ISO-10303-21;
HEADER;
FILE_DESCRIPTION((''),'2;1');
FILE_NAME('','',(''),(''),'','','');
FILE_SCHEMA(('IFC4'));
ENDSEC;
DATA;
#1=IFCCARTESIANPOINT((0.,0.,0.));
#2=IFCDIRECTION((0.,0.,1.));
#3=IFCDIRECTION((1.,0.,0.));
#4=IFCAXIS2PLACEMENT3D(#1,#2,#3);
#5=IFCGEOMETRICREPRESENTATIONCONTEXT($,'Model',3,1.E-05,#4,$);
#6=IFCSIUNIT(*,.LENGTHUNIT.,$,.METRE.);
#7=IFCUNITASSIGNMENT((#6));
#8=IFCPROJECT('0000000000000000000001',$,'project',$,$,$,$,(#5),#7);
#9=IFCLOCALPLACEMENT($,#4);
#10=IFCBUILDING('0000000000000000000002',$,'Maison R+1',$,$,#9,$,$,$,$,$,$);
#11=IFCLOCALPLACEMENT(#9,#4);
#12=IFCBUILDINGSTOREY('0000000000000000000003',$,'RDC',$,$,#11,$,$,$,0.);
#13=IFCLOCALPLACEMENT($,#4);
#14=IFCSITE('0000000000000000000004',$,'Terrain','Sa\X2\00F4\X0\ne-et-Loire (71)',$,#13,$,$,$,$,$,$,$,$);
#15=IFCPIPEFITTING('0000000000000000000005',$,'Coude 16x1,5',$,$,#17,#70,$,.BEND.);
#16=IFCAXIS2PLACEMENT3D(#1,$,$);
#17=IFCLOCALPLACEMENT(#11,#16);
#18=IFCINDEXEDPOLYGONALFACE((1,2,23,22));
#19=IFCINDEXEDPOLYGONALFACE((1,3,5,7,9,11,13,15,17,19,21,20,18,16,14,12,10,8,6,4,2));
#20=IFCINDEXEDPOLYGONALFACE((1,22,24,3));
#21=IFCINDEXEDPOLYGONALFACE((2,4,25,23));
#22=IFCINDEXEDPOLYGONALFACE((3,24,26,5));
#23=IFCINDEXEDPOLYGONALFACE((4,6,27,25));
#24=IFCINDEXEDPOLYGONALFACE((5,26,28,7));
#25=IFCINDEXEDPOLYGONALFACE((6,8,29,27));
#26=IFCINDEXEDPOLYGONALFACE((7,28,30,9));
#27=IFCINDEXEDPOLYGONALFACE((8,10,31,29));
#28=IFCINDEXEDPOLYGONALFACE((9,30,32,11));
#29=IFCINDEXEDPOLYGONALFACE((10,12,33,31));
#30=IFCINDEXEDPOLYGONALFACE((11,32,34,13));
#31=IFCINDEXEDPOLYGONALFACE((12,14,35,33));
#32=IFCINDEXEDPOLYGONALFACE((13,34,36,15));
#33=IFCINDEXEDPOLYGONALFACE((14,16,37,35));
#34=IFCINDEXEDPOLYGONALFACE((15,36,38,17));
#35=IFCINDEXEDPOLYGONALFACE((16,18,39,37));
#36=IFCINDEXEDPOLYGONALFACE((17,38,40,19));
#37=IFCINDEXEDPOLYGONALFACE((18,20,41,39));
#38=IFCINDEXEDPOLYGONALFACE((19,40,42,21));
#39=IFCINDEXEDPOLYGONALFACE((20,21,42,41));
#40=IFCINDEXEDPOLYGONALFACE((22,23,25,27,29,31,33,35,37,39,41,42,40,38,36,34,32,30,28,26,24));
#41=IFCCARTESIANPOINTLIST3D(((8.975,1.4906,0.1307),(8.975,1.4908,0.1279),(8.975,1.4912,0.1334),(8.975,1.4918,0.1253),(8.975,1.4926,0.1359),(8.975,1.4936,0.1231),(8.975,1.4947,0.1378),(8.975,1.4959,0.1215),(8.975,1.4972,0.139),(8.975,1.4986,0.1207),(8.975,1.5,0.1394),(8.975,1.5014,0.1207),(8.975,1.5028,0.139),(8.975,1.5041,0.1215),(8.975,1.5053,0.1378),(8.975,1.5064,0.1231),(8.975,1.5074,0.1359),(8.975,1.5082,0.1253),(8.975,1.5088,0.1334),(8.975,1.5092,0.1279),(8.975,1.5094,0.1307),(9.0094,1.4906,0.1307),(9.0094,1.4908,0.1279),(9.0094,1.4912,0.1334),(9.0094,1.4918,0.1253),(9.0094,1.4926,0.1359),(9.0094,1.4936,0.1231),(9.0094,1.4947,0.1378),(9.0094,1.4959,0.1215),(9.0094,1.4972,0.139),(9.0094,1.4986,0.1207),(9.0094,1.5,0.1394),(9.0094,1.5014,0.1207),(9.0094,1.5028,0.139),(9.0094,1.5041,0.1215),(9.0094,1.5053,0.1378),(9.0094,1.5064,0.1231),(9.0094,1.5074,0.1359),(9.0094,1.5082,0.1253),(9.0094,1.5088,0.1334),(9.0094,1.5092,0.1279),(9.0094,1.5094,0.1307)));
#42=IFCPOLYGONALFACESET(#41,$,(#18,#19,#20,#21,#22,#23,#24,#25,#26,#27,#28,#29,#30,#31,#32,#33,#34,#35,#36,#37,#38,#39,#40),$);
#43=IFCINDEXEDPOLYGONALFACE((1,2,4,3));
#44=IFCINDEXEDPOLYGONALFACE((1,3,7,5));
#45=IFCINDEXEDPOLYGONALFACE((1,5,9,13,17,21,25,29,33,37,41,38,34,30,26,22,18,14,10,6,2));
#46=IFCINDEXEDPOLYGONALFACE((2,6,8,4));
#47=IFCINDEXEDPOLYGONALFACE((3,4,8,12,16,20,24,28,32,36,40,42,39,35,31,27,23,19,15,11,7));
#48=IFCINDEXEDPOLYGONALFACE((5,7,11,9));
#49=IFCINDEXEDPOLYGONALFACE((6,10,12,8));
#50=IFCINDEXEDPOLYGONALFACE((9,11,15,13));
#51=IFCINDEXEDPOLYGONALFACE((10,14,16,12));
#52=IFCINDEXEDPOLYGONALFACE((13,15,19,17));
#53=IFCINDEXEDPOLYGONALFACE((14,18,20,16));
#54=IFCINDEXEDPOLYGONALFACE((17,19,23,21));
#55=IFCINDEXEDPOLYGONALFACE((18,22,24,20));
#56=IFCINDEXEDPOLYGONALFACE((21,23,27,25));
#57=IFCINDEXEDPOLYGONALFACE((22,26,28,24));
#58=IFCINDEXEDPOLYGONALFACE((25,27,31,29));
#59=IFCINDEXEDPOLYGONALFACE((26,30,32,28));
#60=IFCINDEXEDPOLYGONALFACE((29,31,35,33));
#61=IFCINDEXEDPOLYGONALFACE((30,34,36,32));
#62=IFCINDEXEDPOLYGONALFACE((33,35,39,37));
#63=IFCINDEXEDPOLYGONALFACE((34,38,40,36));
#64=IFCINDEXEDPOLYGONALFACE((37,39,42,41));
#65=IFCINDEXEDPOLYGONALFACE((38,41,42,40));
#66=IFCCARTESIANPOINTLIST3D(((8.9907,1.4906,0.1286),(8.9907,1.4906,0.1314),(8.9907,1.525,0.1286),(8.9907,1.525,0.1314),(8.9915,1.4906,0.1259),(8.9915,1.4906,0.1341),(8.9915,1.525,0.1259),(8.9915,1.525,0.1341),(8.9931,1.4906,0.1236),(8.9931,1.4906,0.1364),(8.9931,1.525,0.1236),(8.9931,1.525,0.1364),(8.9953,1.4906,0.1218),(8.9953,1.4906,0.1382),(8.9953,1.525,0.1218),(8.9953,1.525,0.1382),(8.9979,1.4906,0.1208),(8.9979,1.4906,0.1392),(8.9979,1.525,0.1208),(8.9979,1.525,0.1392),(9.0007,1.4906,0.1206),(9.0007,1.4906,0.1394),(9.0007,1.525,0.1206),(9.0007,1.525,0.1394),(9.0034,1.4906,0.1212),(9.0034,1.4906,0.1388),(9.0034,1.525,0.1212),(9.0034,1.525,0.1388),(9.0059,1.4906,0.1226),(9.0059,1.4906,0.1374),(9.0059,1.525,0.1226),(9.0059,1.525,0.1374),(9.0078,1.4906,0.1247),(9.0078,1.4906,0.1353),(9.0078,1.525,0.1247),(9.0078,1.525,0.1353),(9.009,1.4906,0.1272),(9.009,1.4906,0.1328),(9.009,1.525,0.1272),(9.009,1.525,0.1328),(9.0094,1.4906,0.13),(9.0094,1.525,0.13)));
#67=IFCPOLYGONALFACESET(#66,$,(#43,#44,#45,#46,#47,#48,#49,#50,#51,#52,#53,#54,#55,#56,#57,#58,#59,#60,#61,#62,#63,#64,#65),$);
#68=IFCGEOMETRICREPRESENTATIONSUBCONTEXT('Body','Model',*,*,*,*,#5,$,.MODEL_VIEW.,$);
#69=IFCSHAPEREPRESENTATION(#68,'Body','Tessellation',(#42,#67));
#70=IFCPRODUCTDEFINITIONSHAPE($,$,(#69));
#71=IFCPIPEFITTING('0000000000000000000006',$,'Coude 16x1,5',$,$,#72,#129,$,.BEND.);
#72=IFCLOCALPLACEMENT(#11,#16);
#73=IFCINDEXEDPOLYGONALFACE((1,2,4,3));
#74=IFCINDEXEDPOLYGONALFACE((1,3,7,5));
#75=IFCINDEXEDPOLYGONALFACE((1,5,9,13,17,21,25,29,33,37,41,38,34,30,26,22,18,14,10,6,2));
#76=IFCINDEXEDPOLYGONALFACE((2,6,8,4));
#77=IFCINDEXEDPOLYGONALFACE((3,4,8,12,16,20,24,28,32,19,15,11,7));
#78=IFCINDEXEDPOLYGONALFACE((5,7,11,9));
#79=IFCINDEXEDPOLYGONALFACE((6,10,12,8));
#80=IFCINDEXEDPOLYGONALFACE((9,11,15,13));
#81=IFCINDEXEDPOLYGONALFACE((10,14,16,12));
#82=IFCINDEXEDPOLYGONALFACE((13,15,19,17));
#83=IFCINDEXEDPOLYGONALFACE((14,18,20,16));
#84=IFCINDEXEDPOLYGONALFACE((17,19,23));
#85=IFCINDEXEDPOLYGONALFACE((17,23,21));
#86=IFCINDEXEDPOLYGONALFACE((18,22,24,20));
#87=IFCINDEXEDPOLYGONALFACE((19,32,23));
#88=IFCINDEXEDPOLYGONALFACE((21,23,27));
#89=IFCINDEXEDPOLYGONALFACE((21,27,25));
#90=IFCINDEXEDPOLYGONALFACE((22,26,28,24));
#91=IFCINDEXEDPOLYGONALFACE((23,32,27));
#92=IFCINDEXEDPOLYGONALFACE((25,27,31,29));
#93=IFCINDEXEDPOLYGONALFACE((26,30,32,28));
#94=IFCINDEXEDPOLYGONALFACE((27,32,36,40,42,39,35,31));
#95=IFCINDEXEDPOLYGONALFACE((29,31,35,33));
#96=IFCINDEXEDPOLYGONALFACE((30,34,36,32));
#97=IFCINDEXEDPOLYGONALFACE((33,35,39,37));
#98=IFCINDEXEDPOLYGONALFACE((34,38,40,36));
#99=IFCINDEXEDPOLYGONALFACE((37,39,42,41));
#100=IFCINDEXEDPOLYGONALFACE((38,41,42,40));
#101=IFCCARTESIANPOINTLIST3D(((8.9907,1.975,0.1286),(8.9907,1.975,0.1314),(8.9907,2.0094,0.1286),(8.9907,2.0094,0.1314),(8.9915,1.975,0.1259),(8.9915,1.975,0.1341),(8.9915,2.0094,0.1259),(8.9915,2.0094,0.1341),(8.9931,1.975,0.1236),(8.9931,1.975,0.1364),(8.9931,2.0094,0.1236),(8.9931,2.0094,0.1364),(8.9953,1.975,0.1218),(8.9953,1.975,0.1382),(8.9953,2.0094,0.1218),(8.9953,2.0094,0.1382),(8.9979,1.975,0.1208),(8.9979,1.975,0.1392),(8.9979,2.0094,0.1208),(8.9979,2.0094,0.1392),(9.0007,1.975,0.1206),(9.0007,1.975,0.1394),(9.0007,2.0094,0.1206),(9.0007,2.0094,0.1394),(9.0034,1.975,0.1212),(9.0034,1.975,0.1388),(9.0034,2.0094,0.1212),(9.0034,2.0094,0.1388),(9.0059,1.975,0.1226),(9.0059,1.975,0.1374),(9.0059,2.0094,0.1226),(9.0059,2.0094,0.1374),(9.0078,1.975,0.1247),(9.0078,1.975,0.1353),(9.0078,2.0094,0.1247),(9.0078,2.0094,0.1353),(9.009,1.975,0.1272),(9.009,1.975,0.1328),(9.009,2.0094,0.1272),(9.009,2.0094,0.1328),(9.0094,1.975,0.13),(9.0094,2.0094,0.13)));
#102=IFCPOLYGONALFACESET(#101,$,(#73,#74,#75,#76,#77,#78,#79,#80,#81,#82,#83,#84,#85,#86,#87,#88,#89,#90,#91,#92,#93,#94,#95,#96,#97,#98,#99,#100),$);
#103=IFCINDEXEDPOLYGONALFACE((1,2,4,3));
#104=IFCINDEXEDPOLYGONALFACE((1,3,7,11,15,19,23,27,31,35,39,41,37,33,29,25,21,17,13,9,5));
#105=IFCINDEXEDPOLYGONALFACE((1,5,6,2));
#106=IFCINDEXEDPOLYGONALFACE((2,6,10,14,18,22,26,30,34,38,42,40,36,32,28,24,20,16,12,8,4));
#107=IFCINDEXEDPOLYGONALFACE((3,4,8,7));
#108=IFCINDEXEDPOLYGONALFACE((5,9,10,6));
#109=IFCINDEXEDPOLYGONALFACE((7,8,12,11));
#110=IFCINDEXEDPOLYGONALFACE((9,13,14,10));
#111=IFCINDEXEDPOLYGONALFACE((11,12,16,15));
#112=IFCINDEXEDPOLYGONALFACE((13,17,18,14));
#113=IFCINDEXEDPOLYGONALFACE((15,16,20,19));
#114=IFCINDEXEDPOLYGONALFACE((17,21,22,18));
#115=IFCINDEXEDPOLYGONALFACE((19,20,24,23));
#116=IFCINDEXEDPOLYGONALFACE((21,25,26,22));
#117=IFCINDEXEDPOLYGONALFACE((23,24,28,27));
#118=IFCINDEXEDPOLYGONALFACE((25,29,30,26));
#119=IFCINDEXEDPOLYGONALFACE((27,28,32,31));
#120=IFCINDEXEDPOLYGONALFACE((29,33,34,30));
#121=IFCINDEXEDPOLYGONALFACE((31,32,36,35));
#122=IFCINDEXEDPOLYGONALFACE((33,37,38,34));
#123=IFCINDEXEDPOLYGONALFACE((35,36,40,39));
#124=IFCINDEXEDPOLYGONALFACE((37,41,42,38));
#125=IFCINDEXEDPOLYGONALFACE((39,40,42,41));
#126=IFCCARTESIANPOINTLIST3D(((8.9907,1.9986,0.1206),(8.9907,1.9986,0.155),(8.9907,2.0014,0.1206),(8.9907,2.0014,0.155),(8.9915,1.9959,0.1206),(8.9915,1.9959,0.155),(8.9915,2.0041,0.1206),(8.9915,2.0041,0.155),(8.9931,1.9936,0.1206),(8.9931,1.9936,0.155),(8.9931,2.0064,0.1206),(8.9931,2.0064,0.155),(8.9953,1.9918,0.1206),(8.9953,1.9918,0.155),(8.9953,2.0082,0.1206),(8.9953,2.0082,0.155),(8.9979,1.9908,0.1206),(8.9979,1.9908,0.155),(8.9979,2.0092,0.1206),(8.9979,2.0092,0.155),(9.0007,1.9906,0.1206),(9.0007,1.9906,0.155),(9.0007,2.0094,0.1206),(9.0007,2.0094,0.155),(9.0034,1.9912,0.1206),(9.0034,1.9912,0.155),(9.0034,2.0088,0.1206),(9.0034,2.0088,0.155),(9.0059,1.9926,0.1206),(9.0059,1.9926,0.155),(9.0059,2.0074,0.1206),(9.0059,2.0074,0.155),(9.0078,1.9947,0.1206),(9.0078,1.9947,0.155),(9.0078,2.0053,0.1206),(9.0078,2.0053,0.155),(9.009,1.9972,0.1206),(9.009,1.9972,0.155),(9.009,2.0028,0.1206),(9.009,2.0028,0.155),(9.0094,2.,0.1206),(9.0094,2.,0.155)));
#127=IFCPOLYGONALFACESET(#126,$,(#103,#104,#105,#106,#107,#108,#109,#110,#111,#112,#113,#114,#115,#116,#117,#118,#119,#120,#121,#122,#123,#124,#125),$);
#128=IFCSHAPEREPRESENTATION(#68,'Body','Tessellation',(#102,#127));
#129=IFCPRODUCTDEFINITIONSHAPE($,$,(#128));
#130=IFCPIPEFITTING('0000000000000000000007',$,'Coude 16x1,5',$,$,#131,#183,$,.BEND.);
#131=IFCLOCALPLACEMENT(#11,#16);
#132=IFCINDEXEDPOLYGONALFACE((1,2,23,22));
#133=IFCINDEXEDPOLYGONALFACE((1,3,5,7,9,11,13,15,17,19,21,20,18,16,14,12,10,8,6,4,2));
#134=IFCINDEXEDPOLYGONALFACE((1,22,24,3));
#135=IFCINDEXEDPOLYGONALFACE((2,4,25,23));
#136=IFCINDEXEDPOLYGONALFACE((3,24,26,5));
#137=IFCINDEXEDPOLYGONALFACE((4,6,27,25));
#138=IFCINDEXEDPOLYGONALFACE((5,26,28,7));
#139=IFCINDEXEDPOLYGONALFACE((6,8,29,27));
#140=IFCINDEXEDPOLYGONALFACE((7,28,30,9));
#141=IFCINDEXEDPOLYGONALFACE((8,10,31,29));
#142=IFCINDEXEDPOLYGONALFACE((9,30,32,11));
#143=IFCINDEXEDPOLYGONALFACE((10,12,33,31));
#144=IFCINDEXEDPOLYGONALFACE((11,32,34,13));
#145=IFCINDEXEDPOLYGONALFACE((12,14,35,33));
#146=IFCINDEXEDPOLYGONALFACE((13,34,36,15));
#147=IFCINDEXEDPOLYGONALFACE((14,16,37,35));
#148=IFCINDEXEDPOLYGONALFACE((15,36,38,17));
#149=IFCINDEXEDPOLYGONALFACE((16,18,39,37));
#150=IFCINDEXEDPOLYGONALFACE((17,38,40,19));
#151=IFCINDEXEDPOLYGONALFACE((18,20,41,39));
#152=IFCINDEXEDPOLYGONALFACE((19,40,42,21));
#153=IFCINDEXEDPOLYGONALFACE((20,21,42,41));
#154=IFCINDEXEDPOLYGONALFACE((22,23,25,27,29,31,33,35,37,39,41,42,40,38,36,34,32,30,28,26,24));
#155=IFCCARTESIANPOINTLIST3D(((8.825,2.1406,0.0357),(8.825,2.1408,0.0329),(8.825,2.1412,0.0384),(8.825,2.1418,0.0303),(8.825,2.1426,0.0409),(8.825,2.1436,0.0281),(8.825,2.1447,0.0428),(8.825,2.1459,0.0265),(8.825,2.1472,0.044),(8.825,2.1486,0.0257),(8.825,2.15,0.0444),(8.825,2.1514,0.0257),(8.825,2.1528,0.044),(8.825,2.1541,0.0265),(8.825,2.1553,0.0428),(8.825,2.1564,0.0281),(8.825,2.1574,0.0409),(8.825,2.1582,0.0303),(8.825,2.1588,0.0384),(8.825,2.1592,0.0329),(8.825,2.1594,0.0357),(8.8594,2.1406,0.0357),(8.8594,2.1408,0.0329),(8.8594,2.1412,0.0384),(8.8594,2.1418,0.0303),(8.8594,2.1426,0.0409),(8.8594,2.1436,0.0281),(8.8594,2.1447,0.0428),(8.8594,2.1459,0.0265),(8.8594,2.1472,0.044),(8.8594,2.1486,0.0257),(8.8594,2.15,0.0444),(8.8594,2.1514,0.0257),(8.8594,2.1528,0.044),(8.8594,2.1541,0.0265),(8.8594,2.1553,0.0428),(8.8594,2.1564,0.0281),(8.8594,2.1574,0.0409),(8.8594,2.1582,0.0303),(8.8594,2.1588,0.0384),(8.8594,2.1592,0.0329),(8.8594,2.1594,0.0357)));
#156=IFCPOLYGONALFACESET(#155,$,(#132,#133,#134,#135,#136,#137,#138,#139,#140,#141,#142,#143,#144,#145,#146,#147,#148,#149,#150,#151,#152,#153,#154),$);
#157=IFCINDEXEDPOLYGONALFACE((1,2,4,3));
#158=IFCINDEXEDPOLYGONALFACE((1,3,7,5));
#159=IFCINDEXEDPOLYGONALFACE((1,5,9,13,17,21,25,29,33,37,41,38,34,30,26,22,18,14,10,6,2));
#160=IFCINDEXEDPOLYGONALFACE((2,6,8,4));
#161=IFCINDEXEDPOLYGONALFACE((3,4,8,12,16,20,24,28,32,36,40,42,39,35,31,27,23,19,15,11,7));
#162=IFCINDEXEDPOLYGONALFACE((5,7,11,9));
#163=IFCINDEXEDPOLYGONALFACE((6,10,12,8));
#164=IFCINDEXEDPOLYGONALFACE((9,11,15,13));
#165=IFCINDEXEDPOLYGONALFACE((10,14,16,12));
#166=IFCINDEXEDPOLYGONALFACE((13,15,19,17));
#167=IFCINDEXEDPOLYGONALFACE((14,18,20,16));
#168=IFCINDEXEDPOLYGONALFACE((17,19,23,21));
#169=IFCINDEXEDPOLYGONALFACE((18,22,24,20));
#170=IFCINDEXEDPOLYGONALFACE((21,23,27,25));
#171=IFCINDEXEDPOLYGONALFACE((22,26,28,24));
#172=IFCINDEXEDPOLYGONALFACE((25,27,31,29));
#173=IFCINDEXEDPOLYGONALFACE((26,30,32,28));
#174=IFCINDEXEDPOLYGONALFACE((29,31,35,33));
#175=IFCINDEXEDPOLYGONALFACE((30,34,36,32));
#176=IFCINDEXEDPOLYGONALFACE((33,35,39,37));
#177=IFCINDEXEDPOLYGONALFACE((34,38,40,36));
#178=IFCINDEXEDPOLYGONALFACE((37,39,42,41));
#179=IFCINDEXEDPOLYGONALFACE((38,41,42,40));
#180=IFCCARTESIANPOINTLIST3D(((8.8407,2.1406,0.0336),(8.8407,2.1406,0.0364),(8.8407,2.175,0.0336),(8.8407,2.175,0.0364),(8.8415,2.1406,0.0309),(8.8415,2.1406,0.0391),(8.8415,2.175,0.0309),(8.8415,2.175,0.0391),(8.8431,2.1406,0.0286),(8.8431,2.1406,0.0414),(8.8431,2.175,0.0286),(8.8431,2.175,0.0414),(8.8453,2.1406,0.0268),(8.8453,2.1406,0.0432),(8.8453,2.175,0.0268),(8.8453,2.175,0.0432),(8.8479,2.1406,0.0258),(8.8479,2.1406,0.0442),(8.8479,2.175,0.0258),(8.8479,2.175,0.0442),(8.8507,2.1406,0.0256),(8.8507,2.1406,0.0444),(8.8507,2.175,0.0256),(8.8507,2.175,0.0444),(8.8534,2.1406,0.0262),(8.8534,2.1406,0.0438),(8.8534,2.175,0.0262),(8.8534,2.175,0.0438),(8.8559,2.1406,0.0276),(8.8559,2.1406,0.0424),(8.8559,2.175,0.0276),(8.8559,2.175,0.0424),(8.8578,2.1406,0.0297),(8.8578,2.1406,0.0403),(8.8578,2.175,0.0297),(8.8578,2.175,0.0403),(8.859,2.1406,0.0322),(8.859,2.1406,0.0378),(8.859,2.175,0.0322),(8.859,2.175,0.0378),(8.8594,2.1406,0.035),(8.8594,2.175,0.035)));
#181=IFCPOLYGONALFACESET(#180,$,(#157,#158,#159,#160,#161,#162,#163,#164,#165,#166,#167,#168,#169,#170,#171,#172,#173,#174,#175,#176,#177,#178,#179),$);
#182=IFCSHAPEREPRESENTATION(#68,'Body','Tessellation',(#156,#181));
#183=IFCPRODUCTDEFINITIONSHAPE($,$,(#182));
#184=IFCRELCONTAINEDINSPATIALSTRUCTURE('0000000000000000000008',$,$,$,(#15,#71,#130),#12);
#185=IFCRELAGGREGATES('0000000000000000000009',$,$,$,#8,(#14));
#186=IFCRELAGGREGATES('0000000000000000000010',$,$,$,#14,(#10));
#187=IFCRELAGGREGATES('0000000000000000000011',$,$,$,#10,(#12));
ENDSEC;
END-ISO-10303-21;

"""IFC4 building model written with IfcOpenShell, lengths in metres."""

from ifc_helpers import new_model, si_unit, frame, origin_with_axes, place, context, subcontext, project, spatial, circle, extrude, element, save


model = new_model("IFC4")

# Units and contexts
model_context = context("Model", 3, precision=1e-05, world=origin_with_axes())
body_context = subcontext(model_context, "Body", "Model", "MODEL_VIEW")
ifc_project = project(units=[si_unit("LENGTHUNIT", "METRE")], contexts=[model_context])

# Site, building, storey
site_placement = place(None, origin_with_axes())
site = spatial("IfcSite", under=ifc_project, at=site_placement, Name="Terrain", Description="Saône-et-Loire (71)")
building_placement = place(None, origin_with_axes())
building = spatial("IfcBuilding", under=site, at=building_placement, Name="Maison R+1")
storey_placement = place(building_placement, origin_with_axes())
storey = spatial("IfcBuildingStorey", under=building, at=storey_placement, Name="RDC", Elevation=0.0)

# Pipe fittings
pipe_fitting_1_placement = place(storey_placement, frame((9.0, 1.5, 0.13), z_axis=(0.0, 0.0, 1.0), x_axis=(1.0, 0.0, 0.0)))
element("IfcPipeFitting", 1, at=pipe_fitting_1_placement, inside=storey, Name="Coude 16x1,5", PredefinedType="BEND", context=body_context, shape_type="SweptSolid", body=[
    extrude(circle(Radius=0.0094), frame((0.0094, 0.0, 0.0), z_axis=(-1.0, 0.0, 0.0), x_axis=(0.0, 0.0, 1.0)), (0.0, 0.0, 1.0), 0.0344),
    extrude(circle(Radius=0.0094), frame((0.0, -0.0094, 0.0), z_axis=(0.0, 1.0, 0.0), x_axis=(1.0, 0.0, 0.0)), (0.0, 0.0, 1.0), 0.0344),
])
pipe_fitting_2_placement = place(storey_placement, frame((9.0, 2.0, 0.13), z_axis=(0.0, 0.0, 1.0), x_axis=(1.0, 0.0, 0.0)))
element("IfcPipeFitting", 2, at=pipe_fitting_2_placement, inside=storey, Name="Coude 16x1,5", PredefinedType="BEND", context=body_context, shape_type="SweptSolid", body=[
    extrude(circle(Radius=0.0094), frame((0.0, 0.0094, 0.0), z_axis=(0.0, -1.0, 0.0), x_axis=(1.0, 0.0, 0.0)), (0.0, 0.0, 1.0), 0.0344),
    extrude(circle(Radius=0.0094), frame((0.0, 0.0, -0.0094), z_axis=(0.0, 0.0, 1.0), x_axis=(1.0, 0.0, 0.0)), (0.0, 0.0, 1.0), 0.0344),
])
pipe_fitting_3_placement = place(storey_placement, frame((8.85, 2.15, 0.035), z_axis=(0.0, 0.0, 1.0), x_axis=(1.0, 0.0, 0.0)))
element("IfcPipeFitting", 3, at=pipe_fitting_3_placement, inside=storey, Name="Coude 16x1,5", PredefinedType="BEND", context=body_context, shape_type="SweptSolid", body=[
    extrude(circle(Radius=0.0094), frame((0.0094, 0.0, 0.0), z_axis=(-1.0, 0.0, 0.0), x_axis=(0.0, 0.0, 1.0)), (0.0, 0.0, 1.0), 0.0344),
    extrude(circle(Radius=0.0094), frame((0.0, -0.0094, 0.0), z_axis=(0.0, 1.0, 0.0), x_axis=(1.0, 0.0, 0.0)), (0.0, 0.0, 1.0), 0.0344),
])

save(model, "model.ifc")
